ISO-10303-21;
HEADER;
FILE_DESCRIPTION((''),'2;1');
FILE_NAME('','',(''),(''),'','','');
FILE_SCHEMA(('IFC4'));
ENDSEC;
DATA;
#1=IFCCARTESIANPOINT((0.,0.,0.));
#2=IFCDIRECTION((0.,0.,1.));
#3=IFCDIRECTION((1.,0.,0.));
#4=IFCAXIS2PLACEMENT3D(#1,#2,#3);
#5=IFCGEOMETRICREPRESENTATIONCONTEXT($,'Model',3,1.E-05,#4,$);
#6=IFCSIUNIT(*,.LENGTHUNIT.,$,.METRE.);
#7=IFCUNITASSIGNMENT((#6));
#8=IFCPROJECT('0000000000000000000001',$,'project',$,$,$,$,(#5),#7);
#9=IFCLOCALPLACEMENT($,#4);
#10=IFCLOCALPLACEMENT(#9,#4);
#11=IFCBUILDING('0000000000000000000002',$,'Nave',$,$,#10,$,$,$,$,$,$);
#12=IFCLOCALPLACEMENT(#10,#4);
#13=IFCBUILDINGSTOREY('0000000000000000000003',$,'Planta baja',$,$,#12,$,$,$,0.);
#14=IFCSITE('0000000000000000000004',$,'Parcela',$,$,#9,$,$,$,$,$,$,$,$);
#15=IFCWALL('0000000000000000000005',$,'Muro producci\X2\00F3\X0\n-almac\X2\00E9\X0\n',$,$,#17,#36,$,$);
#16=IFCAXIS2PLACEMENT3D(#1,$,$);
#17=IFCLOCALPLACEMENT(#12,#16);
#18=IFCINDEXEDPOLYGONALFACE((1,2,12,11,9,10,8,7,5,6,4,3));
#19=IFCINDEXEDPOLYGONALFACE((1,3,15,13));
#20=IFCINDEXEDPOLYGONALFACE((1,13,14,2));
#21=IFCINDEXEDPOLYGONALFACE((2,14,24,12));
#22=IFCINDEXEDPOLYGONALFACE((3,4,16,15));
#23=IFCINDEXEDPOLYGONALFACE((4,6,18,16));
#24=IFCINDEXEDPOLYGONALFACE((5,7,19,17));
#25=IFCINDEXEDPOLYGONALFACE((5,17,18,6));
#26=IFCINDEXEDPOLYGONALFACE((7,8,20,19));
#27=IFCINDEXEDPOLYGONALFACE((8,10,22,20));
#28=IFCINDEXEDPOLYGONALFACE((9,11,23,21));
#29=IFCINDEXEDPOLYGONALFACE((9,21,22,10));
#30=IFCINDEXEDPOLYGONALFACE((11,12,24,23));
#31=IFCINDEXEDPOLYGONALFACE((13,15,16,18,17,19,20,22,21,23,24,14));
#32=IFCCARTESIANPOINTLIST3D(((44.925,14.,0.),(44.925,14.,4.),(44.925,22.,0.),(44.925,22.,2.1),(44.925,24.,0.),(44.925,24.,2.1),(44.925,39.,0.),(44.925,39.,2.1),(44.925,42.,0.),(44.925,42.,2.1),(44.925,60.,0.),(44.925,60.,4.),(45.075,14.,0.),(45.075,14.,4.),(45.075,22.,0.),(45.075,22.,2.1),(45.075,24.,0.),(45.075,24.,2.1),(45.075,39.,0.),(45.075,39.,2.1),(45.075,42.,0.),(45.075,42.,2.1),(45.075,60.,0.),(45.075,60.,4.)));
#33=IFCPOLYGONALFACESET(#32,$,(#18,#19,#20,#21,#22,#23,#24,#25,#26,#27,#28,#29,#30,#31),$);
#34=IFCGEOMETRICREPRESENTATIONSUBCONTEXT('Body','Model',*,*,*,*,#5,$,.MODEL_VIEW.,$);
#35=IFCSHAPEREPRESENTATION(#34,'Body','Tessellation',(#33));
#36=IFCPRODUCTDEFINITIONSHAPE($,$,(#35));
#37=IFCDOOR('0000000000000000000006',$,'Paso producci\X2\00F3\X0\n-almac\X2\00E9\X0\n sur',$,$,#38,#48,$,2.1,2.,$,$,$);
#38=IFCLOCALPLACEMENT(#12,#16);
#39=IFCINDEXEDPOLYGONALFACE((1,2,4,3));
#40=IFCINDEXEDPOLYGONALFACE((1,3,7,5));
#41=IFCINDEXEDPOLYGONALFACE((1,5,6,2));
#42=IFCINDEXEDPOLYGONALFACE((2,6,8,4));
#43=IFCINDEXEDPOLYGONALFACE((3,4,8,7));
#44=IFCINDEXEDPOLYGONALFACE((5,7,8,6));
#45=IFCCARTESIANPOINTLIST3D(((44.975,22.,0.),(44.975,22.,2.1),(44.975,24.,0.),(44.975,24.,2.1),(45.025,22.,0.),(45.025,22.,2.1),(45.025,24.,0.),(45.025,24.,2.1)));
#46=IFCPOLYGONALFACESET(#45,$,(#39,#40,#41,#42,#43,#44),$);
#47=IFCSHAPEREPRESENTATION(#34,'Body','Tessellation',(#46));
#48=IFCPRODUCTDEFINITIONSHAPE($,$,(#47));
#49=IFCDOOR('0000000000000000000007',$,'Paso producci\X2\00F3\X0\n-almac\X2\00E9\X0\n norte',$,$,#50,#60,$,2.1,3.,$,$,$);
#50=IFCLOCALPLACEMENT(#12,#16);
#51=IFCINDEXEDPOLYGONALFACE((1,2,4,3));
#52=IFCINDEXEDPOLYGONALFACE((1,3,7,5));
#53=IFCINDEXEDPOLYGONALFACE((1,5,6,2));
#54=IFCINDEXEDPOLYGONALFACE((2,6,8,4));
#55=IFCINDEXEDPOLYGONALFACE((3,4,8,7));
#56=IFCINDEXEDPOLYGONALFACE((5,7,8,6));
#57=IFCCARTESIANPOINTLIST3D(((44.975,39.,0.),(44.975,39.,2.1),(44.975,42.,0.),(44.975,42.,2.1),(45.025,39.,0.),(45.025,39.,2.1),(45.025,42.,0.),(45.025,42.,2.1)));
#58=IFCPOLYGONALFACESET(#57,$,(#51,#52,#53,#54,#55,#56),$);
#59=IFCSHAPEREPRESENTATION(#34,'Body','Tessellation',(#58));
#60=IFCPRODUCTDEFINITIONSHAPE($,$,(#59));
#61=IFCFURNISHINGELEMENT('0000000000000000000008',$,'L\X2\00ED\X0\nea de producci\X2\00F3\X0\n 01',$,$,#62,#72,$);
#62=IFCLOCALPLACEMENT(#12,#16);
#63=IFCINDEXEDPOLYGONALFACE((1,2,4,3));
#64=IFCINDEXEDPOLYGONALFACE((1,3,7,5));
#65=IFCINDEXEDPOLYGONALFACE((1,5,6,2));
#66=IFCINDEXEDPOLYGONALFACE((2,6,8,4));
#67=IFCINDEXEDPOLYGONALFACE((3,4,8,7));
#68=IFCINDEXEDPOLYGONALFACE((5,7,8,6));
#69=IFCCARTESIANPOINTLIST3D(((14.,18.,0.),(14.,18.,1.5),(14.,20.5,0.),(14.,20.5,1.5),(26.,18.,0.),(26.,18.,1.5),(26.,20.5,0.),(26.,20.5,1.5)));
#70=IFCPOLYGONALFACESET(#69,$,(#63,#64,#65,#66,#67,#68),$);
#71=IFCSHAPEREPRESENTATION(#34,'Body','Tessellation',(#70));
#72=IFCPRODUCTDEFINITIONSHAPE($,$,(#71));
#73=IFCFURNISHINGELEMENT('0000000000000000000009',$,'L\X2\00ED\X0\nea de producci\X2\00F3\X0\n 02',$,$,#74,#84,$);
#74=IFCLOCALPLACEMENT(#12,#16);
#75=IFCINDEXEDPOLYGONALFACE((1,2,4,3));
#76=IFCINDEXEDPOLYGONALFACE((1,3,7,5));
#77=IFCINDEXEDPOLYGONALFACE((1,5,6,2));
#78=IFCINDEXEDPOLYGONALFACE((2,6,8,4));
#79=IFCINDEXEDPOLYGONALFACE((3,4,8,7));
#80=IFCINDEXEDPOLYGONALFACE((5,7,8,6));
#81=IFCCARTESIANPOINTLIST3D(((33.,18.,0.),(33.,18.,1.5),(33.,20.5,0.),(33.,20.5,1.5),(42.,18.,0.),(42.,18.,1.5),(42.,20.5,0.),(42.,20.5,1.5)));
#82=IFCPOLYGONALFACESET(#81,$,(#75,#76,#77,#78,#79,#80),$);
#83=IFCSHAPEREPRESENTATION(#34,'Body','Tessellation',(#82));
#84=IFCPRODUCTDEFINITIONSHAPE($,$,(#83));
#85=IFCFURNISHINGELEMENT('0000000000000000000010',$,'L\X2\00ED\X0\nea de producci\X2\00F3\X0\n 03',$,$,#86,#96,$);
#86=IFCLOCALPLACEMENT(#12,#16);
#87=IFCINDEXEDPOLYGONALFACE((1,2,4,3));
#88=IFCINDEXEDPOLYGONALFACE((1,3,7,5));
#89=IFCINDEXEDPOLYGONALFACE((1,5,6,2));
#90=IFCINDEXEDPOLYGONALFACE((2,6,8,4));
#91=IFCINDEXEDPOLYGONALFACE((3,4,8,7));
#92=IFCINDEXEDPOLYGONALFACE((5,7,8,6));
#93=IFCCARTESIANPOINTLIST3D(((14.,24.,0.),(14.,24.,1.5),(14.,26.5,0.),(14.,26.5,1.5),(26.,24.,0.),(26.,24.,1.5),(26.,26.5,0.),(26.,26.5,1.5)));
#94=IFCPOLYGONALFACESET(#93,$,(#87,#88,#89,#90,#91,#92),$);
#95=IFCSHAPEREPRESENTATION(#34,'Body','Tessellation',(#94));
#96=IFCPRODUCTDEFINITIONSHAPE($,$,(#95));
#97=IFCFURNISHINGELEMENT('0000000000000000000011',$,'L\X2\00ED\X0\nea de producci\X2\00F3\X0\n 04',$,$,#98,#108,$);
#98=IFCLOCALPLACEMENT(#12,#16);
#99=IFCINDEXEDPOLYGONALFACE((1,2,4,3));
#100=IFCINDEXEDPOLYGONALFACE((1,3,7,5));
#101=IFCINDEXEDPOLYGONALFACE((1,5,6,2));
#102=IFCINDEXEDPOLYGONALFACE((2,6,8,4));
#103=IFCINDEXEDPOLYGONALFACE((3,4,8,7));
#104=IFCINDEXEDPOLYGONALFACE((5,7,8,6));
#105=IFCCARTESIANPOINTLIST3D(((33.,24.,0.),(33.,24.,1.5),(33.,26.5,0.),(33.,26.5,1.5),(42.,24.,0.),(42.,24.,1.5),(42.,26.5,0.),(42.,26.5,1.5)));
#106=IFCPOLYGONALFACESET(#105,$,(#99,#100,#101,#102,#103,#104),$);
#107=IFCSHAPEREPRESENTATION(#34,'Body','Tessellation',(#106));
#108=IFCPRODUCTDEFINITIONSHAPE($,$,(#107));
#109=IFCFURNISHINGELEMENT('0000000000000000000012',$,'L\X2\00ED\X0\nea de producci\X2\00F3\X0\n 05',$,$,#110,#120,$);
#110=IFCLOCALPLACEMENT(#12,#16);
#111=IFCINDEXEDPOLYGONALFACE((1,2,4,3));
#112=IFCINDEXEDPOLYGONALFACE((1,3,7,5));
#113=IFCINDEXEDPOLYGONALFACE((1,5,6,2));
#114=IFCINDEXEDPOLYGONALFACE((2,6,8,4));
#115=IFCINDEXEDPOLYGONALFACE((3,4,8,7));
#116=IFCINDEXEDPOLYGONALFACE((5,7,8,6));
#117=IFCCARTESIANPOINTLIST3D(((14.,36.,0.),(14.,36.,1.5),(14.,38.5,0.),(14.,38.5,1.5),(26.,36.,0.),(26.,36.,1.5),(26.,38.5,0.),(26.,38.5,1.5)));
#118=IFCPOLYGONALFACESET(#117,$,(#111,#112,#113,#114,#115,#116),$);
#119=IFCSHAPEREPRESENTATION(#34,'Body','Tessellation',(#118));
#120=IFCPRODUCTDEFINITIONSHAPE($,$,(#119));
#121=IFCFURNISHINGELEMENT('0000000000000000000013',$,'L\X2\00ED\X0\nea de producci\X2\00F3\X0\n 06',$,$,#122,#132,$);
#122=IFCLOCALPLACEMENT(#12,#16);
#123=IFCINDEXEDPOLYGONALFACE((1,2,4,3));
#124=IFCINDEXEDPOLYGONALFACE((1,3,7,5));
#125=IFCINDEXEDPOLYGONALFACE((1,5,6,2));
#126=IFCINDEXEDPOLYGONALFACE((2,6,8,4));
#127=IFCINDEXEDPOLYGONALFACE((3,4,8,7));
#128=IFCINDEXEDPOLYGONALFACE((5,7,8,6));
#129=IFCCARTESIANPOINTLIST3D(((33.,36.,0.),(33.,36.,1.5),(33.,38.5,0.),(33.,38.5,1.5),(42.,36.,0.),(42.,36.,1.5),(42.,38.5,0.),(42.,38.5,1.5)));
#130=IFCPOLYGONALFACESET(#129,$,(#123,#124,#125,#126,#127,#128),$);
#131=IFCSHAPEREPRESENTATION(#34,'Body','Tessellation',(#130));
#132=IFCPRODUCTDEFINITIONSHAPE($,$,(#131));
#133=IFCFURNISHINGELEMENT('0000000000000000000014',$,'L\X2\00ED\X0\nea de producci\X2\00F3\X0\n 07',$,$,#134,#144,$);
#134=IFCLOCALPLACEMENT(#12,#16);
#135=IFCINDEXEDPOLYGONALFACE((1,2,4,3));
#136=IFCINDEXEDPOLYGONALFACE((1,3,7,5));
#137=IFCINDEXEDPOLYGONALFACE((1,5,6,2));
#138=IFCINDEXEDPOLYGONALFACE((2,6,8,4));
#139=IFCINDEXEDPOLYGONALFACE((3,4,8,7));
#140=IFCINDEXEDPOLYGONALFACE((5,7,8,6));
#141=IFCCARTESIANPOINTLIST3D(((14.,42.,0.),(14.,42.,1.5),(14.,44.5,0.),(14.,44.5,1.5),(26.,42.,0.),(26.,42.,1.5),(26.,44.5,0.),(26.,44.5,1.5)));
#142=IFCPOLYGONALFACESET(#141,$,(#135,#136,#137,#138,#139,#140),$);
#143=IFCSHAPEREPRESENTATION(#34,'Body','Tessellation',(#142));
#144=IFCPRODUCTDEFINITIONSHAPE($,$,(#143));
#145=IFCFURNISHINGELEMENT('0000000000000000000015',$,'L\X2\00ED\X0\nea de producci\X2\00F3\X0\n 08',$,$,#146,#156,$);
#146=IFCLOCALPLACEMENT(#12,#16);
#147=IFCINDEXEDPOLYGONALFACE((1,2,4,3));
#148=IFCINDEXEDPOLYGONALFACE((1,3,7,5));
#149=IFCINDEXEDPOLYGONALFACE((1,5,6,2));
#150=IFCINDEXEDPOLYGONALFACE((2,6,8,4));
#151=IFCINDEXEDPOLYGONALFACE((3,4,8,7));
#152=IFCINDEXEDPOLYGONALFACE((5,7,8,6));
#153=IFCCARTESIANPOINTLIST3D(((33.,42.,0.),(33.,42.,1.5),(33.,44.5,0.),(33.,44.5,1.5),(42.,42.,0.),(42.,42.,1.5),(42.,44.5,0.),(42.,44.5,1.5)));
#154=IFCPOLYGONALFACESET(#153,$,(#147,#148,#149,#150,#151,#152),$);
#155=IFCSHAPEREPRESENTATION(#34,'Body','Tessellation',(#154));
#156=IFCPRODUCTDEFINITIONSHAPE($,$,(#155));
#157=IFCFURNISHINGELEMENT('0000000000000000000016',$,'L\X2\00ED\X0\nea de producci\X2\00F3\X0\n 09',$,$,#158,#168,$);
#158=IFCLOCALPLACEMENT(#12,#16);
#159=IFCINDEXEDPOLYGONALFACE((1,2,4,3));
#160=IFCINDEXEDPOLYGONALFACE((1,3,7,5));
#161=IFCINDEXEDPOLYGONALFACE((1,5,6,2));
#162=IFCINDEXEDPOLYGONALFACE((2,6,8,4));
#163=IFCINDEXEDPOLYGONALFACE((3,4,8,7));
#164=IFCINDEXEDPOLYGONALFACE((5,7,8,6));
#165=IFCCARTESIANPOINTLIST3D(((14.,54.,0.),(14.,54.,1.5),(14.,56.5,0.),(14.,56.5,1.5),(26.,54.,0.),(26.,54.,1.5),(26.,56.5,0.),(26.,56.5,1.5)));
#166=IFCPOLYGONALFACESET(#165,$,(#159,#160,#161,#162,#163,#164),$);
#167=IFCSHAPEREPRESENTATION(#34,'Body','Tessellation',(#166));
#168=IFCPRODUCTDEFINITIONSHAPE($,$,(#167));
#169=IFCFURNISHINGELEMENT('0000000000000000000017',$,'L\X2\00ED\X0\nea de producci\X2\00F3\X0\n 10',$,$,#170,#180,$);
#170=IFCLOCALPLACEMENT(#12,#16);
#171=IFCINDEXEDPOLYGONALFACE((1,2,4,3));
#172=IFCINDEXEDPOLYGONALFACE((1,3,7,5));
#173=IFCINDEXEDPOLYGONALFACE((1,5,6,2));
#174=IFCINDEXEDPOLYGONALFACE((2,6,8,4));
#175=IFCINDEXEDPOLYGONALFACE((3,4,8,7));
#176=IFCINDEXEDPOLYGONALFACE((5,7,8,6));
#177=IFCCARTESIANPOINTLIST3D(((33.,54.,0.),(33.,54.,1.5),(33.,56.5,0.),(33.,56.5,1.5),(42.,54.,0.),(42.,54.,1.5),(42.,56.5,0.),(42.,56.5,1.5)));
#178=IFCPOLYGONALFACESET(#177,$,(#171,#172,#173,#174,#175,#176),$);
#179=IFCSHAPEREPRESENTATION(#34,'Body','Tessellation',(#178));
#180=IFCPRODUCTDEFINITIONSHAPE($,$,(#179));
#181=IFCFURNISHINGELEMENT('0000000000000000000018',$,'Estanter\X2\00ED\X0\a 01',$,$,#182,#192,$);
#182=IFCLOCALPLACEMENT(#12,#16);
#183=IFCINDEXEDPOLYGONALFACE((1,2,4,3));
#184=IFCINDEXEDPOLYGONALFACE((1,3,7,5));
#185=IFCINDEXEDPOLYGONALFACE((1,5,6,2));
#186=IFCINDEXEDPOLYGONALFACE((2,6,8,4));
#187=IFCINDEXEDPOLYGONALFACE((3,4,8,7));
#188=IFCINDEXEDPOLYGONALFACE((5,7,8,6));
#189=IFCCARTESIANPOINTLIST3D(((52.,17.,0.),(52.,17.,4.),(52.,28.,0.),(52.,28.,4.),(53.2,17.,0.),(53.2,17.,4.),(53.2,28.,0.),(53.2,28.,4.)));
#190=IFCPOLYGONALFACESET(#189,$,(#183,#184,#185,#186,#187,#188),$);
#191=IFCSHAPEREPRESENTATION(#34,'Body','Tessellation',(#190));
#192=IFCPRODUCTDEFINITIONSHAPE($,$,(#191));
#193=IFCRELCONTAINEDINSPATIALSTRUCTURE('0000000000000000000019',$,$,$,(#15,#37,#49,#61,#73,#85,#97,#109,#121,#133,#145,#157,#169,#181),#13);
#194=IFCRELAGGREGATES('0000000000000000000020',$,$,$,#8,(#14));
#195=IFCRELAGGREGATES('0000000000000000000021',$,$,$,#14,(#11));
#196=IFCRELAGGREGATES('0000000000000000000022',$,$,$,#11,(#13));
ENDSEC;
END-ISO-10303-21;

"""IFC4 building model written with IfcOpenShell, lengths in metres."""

from ifc_helpers import new_model, si_unit, frame, origin_with_axes, place, context, subcontext, project, spatial, indexed_curve, outline, extrude, element, fill, save


model = new_model("IFC4")

# Units and contexts
model_context = context("Model", 3, precision=1e-05, world=origin_with_axes())
body_context = subcontext(model_context, "Body", "Model", "MODEL_VIEW")
ifc_project = project(units=[si_unit("LENGTHUNIT", "METRE")], contexts=[model_context])

# Site, building, storey
site_placement = place(None, origin_with_axes())
site = spatial("IfcSite", under=ifc_project, at=site_placement, Name="Parcela")
building_placement = place(site_placement, origin_with_axes())
building = spatial("IfcBuilding", under=site, at=building_placement, Name="Nave")
storey_placement = place(building_placement, origin_with_axes())
storey = spatial("IfcBuildingStorey", under=building, at=storey_placement, Name="Planta baja", Elevation=0.0)

# Wall, openings, doors
wall_1_placement = place(storey_placement, frame((45.075, 14.0, 0.0), z_axis=(0.0, 0.0, 1.0), x_axis=(0.0, 1.0, 0.0)))
wall_1 = element("IfcWall", 1, at=wall_1_placement, inside=storey, Name="Muro producción-almacén", context=body_context, shape_type="SweptSolid", body=[
    extrude(outline(indexed_curve([(0.0, 0.0), (0.0, 0.15), (46.0, 0.15), (46.0, 0.0), (0.0, 0.0)], self_intersect=False)), origin_with_axes(), (0.0, 0.0, 1.0), 4.0),
])
opening_1_placement = place(wall_1_placement, frame((8.0, -0.05, 0.0), z_axis=(0.0, 0.0, 1.0), x_axis=(1.0, 0.0, 0.0)))
opening_1 = element("IfcOpeningElement", 2, at=opening_1_placement, cuts=wall_1, context=body_context, shape_type="SweptSolid", body=[
    extrude(outline(indexed_curve([(0.0, 0.0), (0.0, 0.25), (2.0, 0.25), (2.0, 0.0), (0.0, 0.0)], self_intersect=False)), origin_with_axes(), (0.0, 0.0, 1.0), 2.1),
])
opening_2_placement = place(wall_1_placement, frame((25.0, -0.05, 0.0), z_axis=(0.0, 0.0, 1.0), x_axis=(1.0, 0.0, 0.0)))
opening_2 = element("IfcOpeningElement", 3, at=opening_2_placement, cuts=wall_1, context=body_context, shape_type="SweptSolid", body=[
    extrude(outline(indexed_curve([(0.0, 0.0), (0.0, 0.25), (3.0, 0.25), (3.0, 0.0), (0.0, 0.0)], self_intersect=False)), origin_with_axes(), (0.0, 0.0, 1.0), 2.1),
])
door_1_placement = place(opening_1_placement, frame((0.0, 0.1, 0.0), z_axis=(0.0, 0.0, 1.0), x_axis=(1.0, 0.0, 0.0)))
door_1 = element("IfcDoor", 4, at=door_1_placement, inside=storey, Name="Paso producción-almacén sur", OverallHeight=2.1, OverallWidth=2.0, context=body_context, shape_type="SweptSolid", body=[
    extrude(outline(indexed_curve([(0.0, 0.0), (0.0, 0.05), (2.0, 0.05), (2.0, 0.0), (0.0, 0.0)], self_intersect=False)), origin_with_axes(), (0.0, 0.0, 1.0), 2.1),
])
fill(opening_1, door_1)
door_2_placement = place(opening_2_placement, frame((0.0, 0.1, 0.0), z_axis=(0.0, 0.0, 1.0), x_axis=(1.0, 0.0, 0.0)))
door_2 = element("IfcDoor", 5, at=door_2_placement, inside=storey, Name="Paso producción-almacén norte", OverallHeight=2.1, OverallWidth=3.0, context=body_context, shape_type="SweptSolid", body=[
    extrude(outline(indexed_curve([(0.0, 0.0), (0.0, 0.05), (3.0, 0.05), (3.0, 0.0), (0.0, 0.0)], self_intersect=False)), origin_with_axes(), (0.0, 0.0, 1.0), 2.1),
])
fill(opening_2, door_2)

# Furnishing elements
furnishing_1_placement = place(storey_placement, frame((14.0, 18.0, 0.0), z_axis=(0.0, 0.0, 1.0), x_axis=(1.0, 0.0, 0.0)))
element("IfcFurnishingElement", 6, at=furnishing_1_placement, inside=storey, Name="Línea de producción 01", context=body_context, shape_type="SweptSolid", body=[
    extrude(outline(indexed_curve([(0.0, 0.0), (0.0, 2.5), (12.0, 2.5), (12.0, 0.0), (0.0, 0.0)], self_intersect=False)), origin_with_axes(), (0.0, 0.0, 1.0), 1.5),
])
furnishing_2_placement = place(storey_placement, frame((33.0, 18.0, 0.0), z_axis=(0.0, 0.0, 1.0), x_axis=(1.0, 0.0, 0.0)))
element("IfcFurnishingElement", 7, at=furnishing_2_placement, inside=storey, Name="Línea de producción 02", context=body_context, shape_type="SweptSolid", body=[
    extrude(outline(indexed_curve([(0.0, 0.0), (0.0, 2.5), (9.0, 2.5), (9.0, 0.0), (0.0, 0.0)], self_intersect=False)), origin_with_axes(), (0.0, 0.0, 1.0), 1.5),
])
furnishing_3_placement = place(storey_placement, frame((14.0, 24.0, 0.0), z_axis=(0.0, 0.0, 1.0), x_axis=(1.0, 0.0, 0.0)))
element("IfcFurnishingElement", 8, at=furnishing_3_placement, inside=storey, Name="Línea de producción 03", context=body_context, shape_type="SweptSolid", body=[
    extrude(outline(indexed_curve([(0.0, 0.0), (0.0, 2.5), (12.0, 2.5), (12.0, 0.0), (0.0, 0.0)], self_intersect=False)), origin_with_axes(), (0.0, 0.0, 1.0), 1.5),
])
furnishing_4_placement = place(storey_placement, frame((33.0, 24.0, 0.0), z_axis=(0.0, 0.0, 1.0), x_axis=(1.0, 0.0, 0.0)))
element("IfcFurnishingElement", 9, at=furnishing_4_placement, inside=storey, Name="Línea de producción 04", context=body_context, shape_type="SweptSolid", body=[
    extrude(outline(indexed_curve([(0.0, 0.0), (0.0, 2.5), (9.0, 2.5), (9.0, 0.0), (0.0, 0.0)], self_intersect=False)), origin_with_axes(), (0.0, 0.0, 1.0), 1.5),
])
furnishing_5_placement = place(storey_placement, frame((14.0, 36.0, 0.0), z_axis=(0.0, 0.0, 1.0), x_axis=(1.0, 0.0, 0.0)))
element("IfcFurnishingElement", 10, at=furnishing_5_placement, inside=storey, Name="Línea de producción 05", context=body_context, shape_type="SweptSolid", body=[
    extrude(outline(indexed_curve([(0.0, 0.0), (0.0, 2.5), (12.0, 2.5), (12.0, 0.0), (0.0, 0.0)], self_intersect=False)), origin_with_axes(), (0.0, 0.0, 1.0), 1.5),
])
furnishing_6_placement = place(storey_placement, frame((33.0, 36.0, 0.0), z_axis=(0.0, 0.0, 1.0), x_axis=(1.0, 0.0, 0.0)))
element("IfcFurnishingElement", 11, at=furnishing_6_placement, inside=storey, Name="Línea de producción 06", context=body_context, shape_type="SweptSolid", body=[
    extrude(outline(indexed_curve([(0.0, 0.0), (0.0, 2.5), (9.0, 2.5), (9.0, 0.0), (0.0, 0.0)], self_intersect=False)), origin_with_axes(), (0.0, 0.0, 1.0), 1.5),
])
furnishing_7_placement = place(storey_placement, frame((14.0, 42.0, 0.0), z_axis=(0.0, 0.0, 1.0), x_axis=(1.0, 0.0, 0.0)))
element("IfcFurnishingElement", 12, at=furnishing_7_placement, inside=storey, Name="Línea de producción 07", context=body_context, shape_type="SweptSolid", body=[
    extrude(outline(indexed_curve([(0.0, 0.0), (0.0, 2.5), (12.0, 2.5), (12.0, 0.0), (0.0, 0.0)], self_intersect=False)), origin_with_axes(), (0.0, 0.0, 1.0), 1.5),
])
furnishing_8_placement = place(storey_placement, frame((33.0, 42.0, 0.0), z_axis=(0.0, 0.0, 1.0), x_axis=(1.0, 0.0, 0.0)))
element("IfcFurnishingElement", 13, at=furnishing_8_placement, inside=storey, Name="Línea de producción 08", context=body_context, shape_type="SweptSolid", body=[
    extrude(outline(indexed_curve([(0.0, 0.0), (0.0, 2.5), (9.0, 2.5), (9.0, 0.0), (0.0, 0.0)], self_intersect=False)), origin_with_axes(), (0.0, 0.0, 1.0), 1.5),
])
furnishing_9_placement = place(storey_placement, frame((14.0, 54.0, 0.0), z_axis=(0.0, 0.0, 1.0), x_axis=(1.0, 0.0, 0.0)))
element("IfcFurnishingElement", 14, at=furnishing_9_placement, inside=storey, Name="Línea de producción 09", context=body_context, shape_type="SweptSolid", body=[
    extrude(outline(indexed_curve([(0.0, 0.0), (0.0, 2.5), (12.0, 2.5), (12.0, 0.0), (0.0, 0.0)], self_intersect=False)), origin_with_axes(), (0.0, 0.0, 1.0), 1.5),
])
furnishing_10_placement = place(storey_placement, frame((33.0, 54.0, 0.0), z_axis=(0.0, 0.0, 1.0), x_axis=(1.0, 0.0, 0.0)))
element("IfcFurnishingElement", 15, at=furnishing_10_placement, inside=storey, Name="Línea de producción 10", context=body_context, shape_type="SweptSolid", body=[
    extrude(outline(indexed_curve([(0.0, 0.0), (0.0, 2.5), (9.0, 2.5), (9.0, 0.0), (0.0, 0.0)], self_intersect=False)), origin_with_axes(), (0.0, 0.0, 1.0), 1.5),
])
furnishing_11_placement = place(storey_placement, frame((52.0, 17.0, 0.0), z_axis=(0.0, 0.0, 1.0), x_axis=(1.0, 0.0, 0.0)))
element("IfcFurnishingElement", 16, at=furnishing_11_placement, inside=storey, Name="Estantería 01", context=body_context, shape_type="SweptSolid", body=[
    extrude(outline(indexed_curve([(0.0, 0.0), (0.0, 11.0), (1.2, 11.0), (1.2, 0.0), (0.0, 0.0)], self_intersect=False)), origin_with_axes(), (0.0, 0.0, 1.0), 4.0),
])

save(model, "model.ifc")
